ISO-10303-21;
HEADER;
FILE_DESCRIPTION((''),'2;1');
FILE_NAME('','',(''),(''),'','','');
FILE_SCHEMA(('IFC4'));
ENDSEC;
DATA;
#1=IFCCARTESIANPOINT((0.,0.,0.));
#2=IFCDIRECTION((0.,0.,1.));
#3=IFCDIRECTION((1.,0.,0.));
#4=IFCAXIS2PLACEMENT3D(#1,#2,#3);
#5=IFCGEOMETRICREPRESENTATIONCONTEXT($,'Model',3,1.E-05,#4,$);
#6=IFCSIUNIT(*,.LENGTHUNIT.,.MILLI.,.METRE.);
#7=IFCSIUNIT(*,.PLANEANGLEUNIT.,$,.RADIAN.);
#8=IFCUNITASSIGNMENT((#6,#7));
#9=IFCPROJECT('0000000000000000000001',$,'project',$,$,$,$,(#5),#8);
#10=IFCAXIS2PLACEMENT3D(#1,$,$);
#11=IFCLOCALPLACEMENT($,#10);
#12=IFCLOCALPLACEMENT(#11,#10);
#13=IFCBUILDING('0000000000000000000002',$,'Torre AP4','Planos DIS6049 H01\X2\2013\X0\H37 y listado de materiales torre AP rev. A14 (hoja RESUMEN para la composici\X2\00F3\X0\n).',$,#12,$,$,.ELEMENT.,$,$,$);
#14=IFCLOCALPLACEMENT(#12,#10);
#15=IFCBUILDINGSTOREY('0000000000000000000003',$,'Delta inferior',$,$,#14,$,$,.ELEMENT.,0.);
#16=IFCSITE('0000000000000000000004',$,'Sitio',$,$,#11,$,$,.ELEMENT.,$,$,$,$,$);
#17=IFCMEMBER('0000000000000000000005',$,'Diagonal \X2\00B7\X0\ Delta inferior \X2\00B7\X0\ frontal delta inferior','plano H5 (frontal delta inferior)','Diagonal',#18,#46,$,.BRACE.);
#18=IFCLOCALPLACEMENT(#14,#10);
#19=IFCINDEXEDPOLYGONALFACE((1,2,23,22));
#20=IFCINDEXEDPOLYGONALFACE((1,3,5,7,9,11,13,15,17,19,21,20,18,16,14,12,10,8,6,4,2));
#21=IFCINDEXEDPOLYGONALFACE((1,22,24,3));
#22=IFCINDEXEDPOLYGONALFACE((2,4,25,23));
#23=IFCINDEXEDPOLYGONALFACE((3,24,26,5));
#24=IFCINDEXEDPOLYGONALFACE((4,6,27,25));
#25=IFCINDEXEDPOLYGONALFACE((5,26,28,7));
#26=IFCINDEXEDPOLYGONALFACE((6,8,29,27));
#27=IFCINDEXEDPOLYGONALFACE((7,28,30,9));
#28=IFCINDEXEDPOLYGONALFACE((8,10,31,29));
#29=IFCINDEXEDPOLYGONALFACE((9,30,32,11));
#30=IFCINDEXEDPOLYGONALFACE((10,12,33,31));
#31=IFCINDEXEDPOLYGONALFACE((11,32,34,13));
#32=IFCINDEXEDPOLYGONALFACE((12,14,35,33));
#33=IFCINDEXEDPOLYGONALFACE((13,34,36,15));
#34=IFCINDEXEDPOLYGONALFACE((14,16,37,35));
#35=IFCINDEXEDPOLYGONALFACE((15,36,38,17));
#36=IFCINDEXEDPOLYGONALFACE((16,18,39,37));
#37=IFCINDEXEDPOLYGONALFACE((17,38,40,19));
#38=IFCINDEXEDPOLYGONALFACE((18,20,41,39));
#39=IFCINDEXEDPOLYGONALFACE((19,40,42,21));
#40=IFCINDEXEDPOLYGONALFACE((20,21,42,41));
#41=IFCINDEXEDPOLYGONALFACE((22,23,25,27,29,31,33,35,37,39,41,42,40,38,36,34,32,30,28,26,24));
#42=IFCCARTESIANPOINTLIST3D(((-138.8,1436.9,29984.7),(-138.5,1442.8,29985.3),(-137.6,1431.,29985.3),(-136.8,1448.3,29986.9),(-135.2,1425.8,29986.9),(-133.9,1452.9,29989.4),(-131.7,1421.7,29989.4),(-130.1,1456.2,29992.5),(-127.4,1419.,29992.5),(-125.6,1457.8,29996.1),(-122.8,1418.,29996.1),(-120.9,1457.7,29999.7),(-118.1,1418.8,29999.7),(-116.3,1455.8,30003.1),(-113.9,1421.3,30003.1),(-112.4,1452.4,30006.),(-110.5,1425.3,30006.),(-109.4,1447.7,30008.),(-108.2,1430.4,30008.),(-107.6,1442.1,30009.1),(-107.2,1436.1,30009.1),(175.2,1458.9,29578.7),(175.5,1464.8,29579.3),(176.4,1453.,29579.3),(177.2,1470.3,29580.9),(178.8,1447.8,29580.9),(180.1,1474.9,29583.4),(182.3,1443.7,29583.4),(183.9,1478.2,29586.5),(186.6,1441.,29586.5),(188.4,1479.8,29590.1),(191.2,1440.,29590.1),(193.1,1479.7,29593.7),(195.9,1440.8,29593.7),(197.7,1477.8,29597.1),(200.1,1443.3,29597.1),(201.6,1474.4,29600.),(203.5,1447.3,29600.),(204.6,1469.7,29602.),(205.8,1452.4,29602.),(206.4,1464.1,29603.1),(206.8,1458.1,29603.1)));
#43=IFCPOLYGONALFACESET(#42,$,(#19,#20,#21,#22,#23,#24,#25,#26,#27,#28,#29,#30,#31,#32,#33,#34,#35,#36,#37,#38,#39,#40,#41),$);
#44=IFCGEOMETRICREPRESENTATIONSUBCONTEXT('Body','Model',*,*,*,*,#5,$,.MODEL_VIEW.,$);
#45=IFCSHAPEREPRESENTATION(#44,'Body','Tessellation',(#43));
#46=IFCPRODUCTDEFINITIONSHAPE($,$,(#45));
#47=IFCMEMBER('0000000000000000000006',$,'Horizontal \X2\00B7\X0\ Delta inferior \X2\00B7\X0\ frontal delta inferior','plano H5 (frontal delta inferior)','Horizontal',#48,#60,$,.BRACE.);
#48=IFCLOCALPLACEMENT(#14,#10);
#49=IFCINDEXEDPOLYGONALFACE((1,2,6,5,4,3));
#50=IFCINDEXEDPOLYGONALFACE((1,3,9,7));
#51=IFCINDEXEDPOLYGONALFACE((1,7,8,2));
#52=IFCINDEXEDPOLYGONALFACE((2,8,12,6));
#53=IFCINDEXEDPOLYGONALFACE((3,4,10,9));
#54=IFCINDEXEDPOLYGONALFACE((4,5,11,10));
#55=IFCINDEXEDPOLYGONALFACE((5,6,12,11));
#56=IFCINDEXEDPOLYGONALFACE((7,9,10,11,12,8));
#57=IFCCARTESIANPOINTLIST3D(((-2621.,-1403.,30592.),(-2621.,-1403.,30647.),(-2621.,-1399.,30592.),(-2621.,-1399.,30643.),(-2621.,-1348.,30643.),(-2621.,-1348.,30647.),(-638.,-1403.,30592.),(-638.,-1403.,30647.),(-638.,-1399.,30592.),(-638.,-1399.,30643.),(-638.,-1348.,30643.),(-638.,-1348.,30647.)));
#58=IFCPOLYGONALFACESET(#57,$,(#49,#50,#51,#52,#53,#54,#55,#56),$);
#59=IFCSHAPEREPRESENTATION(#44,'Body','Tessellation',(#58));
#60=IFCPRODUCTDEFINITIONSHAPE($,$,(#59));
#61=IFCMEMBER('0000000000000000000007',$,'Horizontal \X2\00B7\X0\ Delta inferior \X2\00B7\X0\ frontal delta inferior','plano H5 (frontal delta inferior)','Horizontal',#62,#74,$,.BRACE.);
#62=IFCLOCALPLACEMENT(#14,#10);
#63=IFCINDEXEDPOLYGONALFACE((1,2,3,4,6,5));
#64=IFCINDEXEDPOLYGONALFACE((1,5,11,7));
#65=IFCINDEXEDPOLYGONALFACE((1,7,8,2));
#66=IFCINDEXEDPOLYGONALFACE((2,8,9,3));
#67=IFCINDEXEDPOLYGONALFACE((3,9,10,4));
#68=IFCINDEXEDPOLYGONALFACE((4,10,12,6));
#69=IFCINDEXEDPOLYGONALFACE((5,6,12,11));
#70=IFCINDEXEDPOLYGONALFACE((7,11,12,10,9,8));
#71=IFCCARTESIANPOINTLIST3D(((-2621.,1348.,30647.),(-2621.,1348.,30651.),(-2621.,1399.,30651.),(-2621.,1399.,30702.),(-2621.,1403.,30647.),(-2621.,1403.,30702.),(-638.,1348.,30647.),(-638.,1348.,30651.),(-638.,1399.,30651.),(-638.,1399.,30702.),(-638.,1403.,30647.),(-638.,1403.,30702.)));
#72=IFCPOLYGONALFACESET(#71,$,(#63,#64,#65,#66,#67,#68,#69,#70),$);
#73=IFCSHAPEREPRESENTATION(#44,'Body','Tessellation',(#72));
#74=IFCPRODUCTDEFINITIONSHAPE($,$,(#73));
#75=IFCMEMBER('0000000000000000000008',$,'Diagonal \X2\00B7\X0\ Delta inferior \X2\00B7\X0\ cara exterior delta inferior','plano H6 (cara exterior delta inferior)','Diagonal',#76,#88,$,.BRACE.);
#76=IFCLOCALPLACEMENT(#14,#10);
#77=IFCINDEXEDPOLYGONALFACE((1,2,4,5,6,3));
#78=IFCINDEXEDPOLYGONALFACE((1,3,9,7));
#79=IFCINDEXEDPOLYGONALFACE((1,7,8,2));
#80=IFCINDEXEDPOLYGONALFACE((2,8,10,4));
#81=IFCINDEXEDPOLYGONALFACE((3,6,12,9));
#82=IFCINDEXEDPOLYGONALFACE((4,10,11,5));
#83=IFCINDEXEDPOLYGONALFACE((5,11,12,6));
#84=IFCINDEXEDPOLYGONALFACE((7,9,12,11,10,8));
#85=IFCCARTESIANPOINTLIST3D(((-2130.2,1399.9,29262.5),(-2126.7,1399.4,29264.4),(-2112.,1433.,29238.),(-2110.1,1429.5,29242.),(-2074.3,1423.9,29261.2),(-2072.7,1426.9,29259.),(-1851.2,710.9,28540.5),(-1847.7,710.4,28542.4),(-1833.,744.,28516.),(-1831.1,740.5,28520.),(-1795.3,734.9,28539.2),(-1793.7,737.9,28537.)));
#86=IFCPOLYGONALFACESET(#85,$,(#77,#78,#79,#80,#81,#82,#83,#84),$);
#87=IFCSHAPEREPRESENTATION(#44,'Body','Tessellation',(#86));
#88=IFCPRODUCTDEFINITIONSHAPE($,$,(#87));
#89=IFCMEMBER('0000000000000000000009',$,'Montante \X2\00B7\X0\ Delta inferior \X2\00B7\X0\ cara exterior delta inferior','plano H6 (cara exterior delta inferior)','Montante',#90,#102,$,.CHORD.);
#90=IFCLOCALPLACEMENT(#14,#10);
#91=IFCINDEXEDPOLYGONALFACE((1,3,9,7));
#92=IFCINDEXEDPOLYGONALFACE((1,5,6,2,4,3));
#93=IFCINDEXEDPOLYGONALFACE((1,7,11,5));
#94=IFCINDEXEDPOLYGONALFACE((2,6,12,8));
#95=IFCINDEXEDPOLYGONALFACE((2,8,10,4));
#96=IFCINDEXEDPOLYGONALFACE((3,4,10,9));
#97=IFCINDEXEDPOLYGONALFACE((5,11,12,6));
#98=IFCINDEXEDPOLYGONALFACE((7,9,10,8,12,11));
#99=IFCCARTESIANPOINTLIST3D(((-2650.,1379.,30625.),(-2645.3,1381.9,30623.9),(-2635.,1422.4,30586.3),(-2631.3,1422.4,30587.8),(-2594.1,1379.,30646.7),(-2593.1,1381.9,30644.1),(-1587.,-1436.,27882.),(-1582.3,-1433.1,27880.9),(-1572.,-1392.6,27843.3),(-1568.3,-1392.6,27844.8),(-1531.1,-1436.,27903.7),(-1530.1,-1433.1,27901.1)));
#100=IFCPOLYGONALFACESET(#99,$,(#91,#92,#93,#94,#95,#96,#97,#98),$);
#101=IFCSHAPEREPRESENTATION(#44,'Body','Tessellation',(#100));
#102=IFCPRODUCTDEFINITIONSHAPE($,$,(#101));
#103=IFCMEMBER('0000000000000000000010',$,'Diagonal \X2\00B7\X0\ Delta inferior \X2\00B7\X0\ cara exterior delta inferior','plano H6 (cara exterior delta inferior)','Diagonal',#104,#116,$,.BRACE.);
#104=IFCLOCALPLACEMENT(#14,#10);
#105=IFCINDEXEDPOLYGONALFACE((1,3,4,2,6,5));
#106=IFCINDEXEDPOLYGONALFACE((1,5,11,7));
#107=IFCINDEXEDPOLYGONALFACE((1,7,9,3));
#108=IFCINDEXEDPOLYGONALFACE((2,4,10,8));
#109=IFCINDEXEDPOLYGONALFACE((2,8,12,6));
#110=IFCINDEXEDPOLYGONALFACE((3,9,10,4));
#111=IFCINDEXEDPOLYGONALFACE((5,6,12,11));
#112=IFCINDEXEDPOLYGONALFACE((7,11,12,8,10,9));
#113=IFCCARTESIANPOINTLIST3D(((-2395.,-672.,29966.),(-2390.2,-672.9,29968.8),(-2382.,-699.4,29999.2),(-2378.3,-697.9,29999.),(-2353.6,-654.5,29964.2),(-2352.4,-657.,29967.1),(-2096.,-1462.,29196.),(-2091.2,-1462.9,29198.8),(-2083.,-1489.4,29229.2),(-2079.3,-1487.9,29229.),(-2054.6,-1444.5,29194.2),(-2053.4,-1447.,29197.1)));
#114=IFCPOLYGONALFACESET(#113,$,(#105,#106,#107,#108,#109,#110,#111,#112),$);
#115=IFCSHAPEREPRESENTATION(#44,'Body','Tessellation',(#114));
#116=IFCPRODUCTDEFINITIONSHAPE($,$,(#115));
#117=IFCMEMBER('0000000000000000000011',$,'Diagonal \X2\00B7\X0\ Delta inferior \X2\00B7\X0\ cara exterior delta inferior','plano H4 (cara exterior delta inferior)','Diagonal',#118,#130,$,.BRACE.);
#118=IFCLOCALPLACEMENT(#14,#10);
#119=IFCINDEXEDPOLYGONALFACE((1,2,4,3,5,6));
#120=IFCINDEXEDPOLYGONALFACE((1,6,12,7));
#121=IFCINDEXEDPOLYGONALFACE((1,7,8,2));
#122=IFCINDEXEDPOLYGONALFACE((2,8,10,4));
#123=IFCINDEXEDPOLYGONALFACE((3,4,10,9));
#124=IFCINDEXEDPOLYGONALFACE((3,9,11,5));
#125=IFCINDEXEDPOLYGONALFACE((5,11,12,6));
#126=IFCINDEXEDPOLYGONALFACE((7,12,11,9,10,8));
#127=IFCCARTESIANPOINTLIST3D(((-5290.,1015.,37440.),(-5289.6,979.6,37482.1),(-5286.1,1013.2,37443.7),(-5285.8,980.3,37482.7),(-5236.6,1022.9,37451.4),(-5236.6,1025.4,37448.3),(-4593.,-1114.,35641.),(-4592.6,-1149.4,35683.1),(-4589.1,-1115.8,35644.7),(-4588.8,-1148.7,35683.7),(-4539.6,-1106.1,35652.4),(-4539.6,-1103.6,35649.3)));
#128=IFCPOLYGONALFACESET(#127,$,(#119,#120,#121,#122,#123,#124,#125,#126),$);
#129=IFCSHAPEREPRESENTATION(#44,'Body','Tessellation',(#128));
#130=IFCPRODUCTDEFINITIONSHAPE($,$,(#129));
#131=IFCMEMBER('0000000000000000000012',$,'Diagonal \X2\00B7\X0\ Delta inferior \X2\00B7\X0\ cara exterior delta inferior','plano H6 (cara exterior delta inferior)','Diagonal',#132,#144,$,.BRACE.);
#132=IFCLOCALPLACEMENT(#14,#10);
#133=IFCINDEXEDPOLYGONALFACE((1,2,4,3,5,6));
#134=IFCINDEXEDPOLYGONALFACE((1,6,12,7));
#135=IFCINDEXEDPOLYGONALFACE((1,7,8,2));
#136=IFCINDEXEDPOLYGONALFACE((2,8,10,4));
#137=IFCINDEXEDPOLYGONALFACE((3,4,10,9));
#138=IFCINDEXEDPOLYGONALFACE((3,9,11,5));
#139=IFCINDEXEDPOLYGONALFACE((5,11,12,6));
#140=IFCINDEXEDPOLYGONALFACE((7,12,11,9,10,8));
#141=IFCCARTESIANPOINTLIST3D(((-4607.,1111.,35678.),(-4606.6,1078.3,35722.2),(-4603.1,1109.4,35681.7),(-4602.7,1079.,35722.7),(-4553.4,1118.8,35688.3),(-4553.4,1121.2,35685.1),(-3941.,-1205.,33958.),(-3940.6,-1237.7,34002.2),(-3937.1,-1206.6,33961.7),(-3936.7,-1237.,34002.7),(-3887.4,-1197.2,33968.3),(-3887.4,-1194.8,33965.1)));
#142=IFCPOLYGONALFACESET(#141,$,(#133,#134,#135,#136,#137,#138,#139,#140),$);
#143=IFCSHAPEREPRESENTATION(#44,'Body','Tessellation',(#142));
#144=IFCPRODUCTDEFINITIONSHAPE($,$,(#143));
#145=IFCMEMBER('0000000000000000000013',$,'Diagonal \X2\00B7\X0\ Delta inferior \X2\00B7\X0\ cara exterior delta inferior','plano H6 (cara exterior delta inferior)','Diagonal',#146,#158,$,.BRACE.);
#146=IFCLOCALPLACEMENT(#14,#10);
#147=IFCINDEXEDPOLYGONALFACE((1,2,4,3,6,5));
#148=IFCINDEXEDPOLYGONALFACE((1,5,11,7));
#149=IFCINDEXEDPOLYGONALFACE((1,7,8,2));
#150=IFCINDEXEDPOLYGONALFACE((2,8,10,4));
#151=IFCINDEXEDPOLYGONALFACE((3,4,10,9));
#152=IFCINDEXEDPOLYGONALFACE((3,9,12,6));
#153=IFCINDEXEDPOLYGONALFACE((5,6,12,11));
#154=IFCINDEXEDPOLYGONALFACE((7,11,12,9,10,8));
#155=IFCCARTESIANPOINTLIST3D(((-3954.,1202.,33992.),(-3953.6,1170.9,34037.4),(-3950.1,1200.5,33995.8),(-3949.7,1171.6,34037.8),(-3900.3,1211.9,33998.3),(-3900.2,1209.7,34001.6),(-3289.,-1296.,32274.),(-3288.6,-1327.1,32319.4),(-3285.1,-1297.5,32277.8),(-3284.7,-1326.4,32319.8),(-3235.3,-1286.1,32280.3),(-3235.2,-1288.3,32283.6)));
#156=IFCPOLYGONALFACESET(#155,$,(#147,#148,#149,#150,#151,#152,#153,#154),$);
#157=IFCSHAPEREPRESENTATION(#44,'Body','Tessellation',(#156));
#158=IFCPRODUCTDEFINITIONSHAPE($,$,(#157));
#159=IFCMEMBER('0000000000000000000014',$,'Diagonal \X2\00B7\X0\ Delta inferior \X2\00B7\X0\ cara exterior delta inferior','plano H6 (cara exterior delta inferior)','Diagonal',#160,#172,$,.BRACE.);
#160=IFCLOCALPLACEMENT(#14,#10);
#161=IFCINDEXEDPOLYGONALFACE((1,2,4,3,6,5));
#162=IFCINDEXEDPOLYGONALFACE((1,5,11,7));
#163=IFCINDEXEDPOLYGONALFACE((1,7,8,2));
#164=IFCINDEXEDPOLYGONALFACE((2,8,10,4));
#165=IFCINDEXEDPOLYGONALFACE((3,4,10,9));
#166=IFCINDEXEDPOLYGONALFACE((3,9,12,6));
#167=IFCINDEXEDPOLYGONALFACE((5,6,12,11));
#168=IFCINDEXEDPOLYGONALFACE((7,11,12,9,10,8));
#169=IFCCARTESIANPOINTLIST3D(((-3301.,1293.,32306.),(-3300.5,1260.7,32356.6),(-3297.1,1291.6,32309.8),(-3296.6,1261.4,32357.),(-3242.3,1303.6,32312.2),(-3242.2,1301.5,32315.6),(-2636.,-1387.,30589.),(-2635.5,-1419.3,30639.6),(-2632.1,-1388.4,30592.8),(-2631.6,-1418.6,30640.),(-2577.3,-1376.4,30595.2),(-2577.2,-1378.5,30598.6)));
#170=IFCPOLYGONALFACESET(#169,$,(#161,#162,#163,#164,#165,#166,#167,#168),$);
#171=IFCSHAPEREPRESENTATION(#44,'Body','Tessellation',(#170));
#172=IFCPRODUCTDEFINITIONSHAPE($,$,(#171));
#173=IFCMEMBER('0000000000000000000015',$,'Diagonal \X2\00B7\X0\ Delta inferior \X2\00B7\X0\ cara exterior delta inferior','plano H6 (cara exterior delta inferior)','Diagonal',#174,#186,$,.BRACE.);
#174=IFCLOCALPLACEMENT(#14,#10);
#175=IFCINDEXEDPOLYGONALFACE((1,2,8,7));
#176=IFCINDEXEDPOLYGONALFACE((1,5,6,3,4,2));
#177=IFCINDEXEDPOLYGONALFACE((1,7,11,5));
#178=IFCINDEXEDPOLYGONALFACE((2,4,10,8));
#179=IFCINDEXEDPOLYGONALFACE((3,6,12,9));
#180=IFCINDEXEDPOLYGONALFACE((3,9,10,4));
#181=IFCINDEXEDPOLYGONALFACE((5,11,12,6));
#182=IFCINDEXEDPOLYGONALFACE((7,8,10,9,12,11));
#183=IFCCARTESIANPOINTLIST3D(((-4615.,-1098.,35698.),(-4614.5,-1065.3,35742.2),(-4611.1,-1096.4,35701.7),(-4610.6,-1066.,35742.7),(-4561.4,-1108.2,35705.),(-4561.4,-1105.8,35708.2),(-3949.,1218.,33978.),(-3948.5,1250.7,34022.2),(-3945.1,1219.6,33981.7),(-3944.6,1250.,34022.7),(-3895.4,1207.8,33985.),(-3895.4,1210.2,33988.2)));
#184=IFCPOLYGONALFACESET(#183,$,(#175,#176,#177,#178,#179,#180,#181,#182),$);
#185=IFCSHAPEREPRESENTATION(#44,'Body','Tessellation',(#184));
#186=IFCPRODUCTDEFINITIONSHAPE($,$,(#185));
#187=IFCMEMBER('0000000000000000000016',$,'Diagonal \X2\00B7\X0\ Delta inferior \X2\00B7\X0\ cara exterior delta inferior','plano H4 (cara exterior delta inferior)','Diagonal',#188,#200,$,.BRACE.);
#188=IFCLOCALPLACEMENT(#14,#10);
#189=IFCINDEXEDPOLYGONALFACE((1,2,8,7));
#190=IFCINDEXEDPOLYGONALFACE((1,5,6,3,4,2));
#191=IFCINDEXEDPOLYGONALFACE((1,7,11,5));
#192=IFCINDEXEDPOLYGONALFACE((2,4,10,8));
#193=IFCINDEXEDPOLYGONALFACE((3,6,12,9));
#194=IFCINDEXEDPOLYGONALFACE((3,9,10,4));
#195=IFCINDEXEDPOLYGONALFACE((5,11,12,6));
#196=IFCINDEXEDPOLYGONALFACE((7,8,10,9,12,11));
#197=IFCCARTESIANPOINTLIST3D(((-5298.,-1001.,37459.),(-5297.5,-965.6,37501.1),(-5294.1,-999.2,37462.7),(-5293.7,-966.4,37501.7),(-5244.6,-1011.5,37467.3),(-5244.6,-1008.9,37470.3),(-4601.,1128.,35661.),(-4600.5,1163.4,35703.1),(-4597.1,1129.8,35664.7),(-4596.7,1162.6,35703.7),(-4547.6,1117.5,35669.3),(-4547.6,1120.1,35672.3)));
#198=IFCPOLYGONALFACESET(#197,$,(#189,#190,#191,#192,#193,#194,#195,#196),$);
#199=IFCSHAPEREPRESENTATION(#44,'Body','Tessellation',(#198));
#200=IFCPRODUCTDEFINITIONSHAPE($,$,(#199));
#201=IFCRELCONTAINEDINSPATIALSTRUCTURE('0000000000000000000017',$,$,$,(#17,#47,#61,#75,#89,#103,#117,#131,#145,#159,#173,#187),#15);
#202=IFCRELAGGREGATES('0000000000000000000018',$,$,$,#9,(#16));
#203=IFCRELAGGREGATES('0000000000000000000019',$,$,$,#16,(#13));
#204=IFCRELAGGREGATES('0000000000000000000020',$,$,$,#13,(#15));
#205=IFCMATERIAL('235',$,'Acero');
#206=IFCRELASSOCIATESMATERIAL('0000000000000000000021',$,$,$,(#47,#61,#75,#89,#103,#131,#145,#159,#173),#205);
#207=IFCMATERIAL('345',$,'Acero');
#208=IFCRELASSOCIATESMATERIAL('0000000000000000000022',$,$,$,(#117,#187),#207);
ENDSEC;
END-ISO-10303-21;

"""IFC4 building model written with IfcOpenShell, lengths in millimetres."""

from ifc_helpers import new_model, si_unit, frame, frame_2d, origin, origin_with_axes, place, context, subcontext, project, spatial, circle, l_section, extrude, material, element, save


model = new_model("IFC4")

# Units and contexts
model_context = context("Model", 3, precision=1e-05, world=origin_with_axes())
body_context = subcontext(model_context, "Body", "Model", "MODEL_VIEW")
ifc_project = project(units=[si_unit("LENGTHUNIT", "METRE", prefix="MILLI"), si_unit("PLANEANGLEUNIT", "RADIAN")], contexts=[model_context])

# Site, building, storey
site_placement = place(None, origin())
site = spatial("IfcSite", under=ifc_project, at=site_placement, Name="Sitio", CompositionType="ELEMENT")
building_placement = place(site_placement, origin())
building = spatial("IfcBuilding", under=site, at=building_placement, Name="Torre AP4", Description="Planos DIS6049 H01–H37 y listado de materiales torre AP rev. A14 (hoja RESUMEN para la composición).", CompositionType="ELEMENT")
storey_placement = place(building_placement, origin())
storey = spatial("IfcBuildingStorey", under=building, at=storey_placement, Name="Delta inferior", CompositionType="ELEMENT", Elevation=0.0)

# Members
ifc_material_1 = material(Name="235", Category="Acero")
for number, where, z_axis, x_axis, name in (
    (1, (191.0, 1460.0, 29591.0), (-0.611219, -0.042824, 0.790302), (0.011492, -0.99891, -0.04524), "Diagonal · Delta inferior · frontal delta inferior"),
):
    element("IfcMember", number, at=place(storey_placement, frame(where, z_axis=z_axis, x_axis=x_axis)), inside=storey, Name=name, Description="plano H5 (frontal delta inferior)", ObjectType="Diagonal", PredefinedType="BRACE", context=body_context, shape_type="SweptSolid", body=[
        extrude(circle(Radius=20.0), None, (0.0, 0.0, 1.0), 513.7),
    ])
for number, where, z_axis, x_axis, name in (
    (2, (-638.0, -1403.0, 30647.0), (-1.0, 0.0, 0.0), (0.0, 1.0, 0.0), "Horizontal · Delta inferior · frontal delta inferior"),
    (3, (-638.0, 1403.0, 30647.0), (-1.0, 0.0, 0.0), (0.0, -1.0, 0.0), "Horizontal · Delta inferior · frontal delta inferior"),
):
    element("IfcMember", number, at=place(storey_placement, frame(where, z_axis=z_axis, x_axis=x_axis)), inside=storey, material=ifc_material_1, Name=name, Description="plano H5 (frontal delta inferior)", ObjectType="Horizontal", PredefinedType="BRACE", context=body_context, shape_type="SweptSolid", body=[
        extrude(l_section(Depth=55.0, Width=55.0, Thickness=4.0, at=frame_2d((27.5, 27.5))), None, (0.0, 0.0, 1.0), 1983.0),
    ])
member_1_placement = place(storey_placement, frame((-2112.0, 1433.0, 29238.0), z_axis=(0.269236, -0.664888, -0.696733), x_axis=(0.873631, -0.135855, 0.46724)))
element("IfcMember", 4, at=member_1_placement, inside=storey, material=ifc_material_1, Name="Diagonal · Delta inferior · cara exterior delta inferior", Description="plano H6 (cara exterior delta inferior)", ObjectType="Diagonal", PredefinedType="BRACE", context=body_context, shape_type="SweptSolid", body=[
    extrude(l_section(Depth=45.0, Width=45.0, Thickness=4.0, at=frame_2d((22.5, 22.5))), None, (0.0, 0.0, 1.0), 1036.3),
])
member_2_placement = place(storey_placement, frame((-2650.0, 1379.0, 30625.0), z_axis=(0.261074, -0.691368, -0.673685), x_axis=(0.249824, 0.722503, -0.644653)))
element("IfcMember", 5, at=member_2_placement, inside=storey, material=ifc_material_1, Name="Montante · Delta inferior · cara exterior delta inferior", Description="plano H6 (cara exterior delta inferior)", ObjectType="Montante", PredefinedType="CHORD", context=body_context, shape_type="SweptSolid", body=[
    extrude(l_section(Depth=60.0, Width=60.0, Thickness=4.0, at=frame_2d((30.0, 30.0))), None, (0.0, 0.0, 1.0), 4071.6),
])
member_3_placement = place(storey_placement, frame((-2395.0, -672.0, 29966.0), z_axis=(0.261597, -0.691176, -0.673678), x_axis=(0.920687, 0.38817, -0.040739)))
element("IfcMember", 6, at=member_3_placement, inside=storey, material=ifc_material_1, Name="Diagonal · Delta inferior · cara exterior delta inferior", Description="plano H6 (cara exterior delta inferior)", ObjectType="Diagonal", PredefinedType="BRACE", context=body_context, shape_type="SweptSolid", body=[
    extrude(l_section(Depth=45.0, Width=45.0, Thickness=4.0, at=frame_2d((22.5, 22.5))), None, (0.0, 0.0, 1.0), 1143.0),
])
ifc_material_2 = material(Name="345", Category="Acero")
member_4_placement = place(storey_placement, frame((-5290.0, 1015.0, 37440.0), z_axis=(0.242593, -0.741005, -0.626147), x_axis=(0.970107, 0.189587, 0.151492)))
element("IfcMember", 7, at=member_4_placement, inside=storey, material=ifc_material_2, Name="Diagonal · Delta inferior · cara exterior delta inferior", Description="plano H4 (cara exterior delta inferior)", ObjectType="Diagonal", PredefinedType="BRACE", context=body_context, shape_type="SweptSolid", body=[
    extrude(l_section(Depth=55.0, Width=55.0, Thickness=4.0, at=frame_2d((27.5, 27.5))), None, (0.0, 0.0, 1.0), 2873.1),
])
member_5_placement = place(storey_placement, frame((-4607.0, 1111.0, 35678.0), z_axis=(0.224946, -0.782244, -0.580941), x_axis=(0.974349, 0.184591, 0.128724)))
element("IfcMember", 8, at=member_5_placement, inside=storey, material=ifc_material_1, Name="Diagonal · Delta inferior · cara exterior delta inferior", Description="plano H6 (cara exterior delta inferior)", ObjectType="Diagonal", PredefinedType="BRACE", context=body_context, shape_type="SweptSolid", body=[
    extrude(l_section(Depth=55.0, Width=55.0, Thickness=4.0, at=frame_2d((27.5, 27.5))), None, (0.0, 0.0, 1.0), 2960.7),
])
member_6_placement = place(storey_placement, frame((-3954.0, 1202.0, 33992.0), z_axis=(0.214252, -0.804812, -0.55351), x_axis=(0.976751, 0.180783, 0.115217)))
element("IfcMember", 9, at=member_6_placement, inside=storey, material=ifc_material_1, Name="Diagonal · Delta inferior · cara exterior delta inferior", Description="plano H6 (cara exterior delta inferior)", ObjectType="Diagonal", PredefinedType="BRACE", context=body_context, shape_type="SweptSolid", body=[
    extrude(l_section(Depth=55.0, Width=55.0, Thickness=4.0, at=frame_2d((27.5, 27.5))), None, (0.0, 0.0, 1.0), 3103.8),
])
member_7_placement = place(storey_placement, frame((-3301.0, 1293.0, 32306.0), z_axis=(0.204517, -0.824217, -0.528052), x_axis=(0.978826, 0.176893, 0.102997)))
element("IfcMember", 10, at=member_7_placement, inside=storey, material=ifc_material_1, Name="Diagonal · Delta inferior · cara exterior delta inferior", Description="plano H6 (cara exterior delta inferior)", ObjectType="Diagonal", PredefinedType="BRACE", context=body_context, shape_type="SweptSolid", body=[
    extrude(l_section(Depth=60.0, Width=60.0, Thickness=4.0, at=frame_2d((30.0, 30.0))), None, (0.0, 0.0, 1.0), 3251.6),
])
member_8_placement = place(storey_placement, frame((-3949.0, 1218.0, 33978.0), z_axis=(-0.224946, -0.782244, 0.580941), x_axis=(0.974336, -0.185683, 0.127247)))
element("IfcMember", 11, at=member_8_placement, inside=storey, material=ifc_material_1, Name="Diagonal · Delta inferior · cara exterior delta inferior", Description="plano H6 (cara exterior delta inferior)", ObjectType="Diagonal", PredefinedType="BRACE", context=body_context, shape_type="SweptSolid", body=[
    extrude(l_section(Depth=55.0, Width=55.0, Thickness=4.0, at=frame_2d((27.5, 27.5))), None, (0.0, 0.0, 1.0), 2960.7),
])
member_9_placement = place(storey_placement, frame((-4601.0, 1128.0, 35661.0), z_axis=(-0.242646, -0.741166, 0.625936), x_axis=(0.97008, -0.190866, 0.150051)))
element("IfcMember", 12, at=member_9_placement, inside=storey, material=ifc_material_2, Name="Diagonal · Delta inferior · cara exterior delta inferior", Description="plano H4 (cara exterior delta inferior)", ObjectType="Diagonal", PredefinedType="BRACE", context=body_context, shape_type="SweptSolid", body=[
    extrude(l_section(Depth=55.0, Width=55.0, Thickness=4.0, at=frame_2d((27.5, 27.5))), None, (0.0, 0.0, 1.0), 2872.5),
])

save(model, "model.ifc")
